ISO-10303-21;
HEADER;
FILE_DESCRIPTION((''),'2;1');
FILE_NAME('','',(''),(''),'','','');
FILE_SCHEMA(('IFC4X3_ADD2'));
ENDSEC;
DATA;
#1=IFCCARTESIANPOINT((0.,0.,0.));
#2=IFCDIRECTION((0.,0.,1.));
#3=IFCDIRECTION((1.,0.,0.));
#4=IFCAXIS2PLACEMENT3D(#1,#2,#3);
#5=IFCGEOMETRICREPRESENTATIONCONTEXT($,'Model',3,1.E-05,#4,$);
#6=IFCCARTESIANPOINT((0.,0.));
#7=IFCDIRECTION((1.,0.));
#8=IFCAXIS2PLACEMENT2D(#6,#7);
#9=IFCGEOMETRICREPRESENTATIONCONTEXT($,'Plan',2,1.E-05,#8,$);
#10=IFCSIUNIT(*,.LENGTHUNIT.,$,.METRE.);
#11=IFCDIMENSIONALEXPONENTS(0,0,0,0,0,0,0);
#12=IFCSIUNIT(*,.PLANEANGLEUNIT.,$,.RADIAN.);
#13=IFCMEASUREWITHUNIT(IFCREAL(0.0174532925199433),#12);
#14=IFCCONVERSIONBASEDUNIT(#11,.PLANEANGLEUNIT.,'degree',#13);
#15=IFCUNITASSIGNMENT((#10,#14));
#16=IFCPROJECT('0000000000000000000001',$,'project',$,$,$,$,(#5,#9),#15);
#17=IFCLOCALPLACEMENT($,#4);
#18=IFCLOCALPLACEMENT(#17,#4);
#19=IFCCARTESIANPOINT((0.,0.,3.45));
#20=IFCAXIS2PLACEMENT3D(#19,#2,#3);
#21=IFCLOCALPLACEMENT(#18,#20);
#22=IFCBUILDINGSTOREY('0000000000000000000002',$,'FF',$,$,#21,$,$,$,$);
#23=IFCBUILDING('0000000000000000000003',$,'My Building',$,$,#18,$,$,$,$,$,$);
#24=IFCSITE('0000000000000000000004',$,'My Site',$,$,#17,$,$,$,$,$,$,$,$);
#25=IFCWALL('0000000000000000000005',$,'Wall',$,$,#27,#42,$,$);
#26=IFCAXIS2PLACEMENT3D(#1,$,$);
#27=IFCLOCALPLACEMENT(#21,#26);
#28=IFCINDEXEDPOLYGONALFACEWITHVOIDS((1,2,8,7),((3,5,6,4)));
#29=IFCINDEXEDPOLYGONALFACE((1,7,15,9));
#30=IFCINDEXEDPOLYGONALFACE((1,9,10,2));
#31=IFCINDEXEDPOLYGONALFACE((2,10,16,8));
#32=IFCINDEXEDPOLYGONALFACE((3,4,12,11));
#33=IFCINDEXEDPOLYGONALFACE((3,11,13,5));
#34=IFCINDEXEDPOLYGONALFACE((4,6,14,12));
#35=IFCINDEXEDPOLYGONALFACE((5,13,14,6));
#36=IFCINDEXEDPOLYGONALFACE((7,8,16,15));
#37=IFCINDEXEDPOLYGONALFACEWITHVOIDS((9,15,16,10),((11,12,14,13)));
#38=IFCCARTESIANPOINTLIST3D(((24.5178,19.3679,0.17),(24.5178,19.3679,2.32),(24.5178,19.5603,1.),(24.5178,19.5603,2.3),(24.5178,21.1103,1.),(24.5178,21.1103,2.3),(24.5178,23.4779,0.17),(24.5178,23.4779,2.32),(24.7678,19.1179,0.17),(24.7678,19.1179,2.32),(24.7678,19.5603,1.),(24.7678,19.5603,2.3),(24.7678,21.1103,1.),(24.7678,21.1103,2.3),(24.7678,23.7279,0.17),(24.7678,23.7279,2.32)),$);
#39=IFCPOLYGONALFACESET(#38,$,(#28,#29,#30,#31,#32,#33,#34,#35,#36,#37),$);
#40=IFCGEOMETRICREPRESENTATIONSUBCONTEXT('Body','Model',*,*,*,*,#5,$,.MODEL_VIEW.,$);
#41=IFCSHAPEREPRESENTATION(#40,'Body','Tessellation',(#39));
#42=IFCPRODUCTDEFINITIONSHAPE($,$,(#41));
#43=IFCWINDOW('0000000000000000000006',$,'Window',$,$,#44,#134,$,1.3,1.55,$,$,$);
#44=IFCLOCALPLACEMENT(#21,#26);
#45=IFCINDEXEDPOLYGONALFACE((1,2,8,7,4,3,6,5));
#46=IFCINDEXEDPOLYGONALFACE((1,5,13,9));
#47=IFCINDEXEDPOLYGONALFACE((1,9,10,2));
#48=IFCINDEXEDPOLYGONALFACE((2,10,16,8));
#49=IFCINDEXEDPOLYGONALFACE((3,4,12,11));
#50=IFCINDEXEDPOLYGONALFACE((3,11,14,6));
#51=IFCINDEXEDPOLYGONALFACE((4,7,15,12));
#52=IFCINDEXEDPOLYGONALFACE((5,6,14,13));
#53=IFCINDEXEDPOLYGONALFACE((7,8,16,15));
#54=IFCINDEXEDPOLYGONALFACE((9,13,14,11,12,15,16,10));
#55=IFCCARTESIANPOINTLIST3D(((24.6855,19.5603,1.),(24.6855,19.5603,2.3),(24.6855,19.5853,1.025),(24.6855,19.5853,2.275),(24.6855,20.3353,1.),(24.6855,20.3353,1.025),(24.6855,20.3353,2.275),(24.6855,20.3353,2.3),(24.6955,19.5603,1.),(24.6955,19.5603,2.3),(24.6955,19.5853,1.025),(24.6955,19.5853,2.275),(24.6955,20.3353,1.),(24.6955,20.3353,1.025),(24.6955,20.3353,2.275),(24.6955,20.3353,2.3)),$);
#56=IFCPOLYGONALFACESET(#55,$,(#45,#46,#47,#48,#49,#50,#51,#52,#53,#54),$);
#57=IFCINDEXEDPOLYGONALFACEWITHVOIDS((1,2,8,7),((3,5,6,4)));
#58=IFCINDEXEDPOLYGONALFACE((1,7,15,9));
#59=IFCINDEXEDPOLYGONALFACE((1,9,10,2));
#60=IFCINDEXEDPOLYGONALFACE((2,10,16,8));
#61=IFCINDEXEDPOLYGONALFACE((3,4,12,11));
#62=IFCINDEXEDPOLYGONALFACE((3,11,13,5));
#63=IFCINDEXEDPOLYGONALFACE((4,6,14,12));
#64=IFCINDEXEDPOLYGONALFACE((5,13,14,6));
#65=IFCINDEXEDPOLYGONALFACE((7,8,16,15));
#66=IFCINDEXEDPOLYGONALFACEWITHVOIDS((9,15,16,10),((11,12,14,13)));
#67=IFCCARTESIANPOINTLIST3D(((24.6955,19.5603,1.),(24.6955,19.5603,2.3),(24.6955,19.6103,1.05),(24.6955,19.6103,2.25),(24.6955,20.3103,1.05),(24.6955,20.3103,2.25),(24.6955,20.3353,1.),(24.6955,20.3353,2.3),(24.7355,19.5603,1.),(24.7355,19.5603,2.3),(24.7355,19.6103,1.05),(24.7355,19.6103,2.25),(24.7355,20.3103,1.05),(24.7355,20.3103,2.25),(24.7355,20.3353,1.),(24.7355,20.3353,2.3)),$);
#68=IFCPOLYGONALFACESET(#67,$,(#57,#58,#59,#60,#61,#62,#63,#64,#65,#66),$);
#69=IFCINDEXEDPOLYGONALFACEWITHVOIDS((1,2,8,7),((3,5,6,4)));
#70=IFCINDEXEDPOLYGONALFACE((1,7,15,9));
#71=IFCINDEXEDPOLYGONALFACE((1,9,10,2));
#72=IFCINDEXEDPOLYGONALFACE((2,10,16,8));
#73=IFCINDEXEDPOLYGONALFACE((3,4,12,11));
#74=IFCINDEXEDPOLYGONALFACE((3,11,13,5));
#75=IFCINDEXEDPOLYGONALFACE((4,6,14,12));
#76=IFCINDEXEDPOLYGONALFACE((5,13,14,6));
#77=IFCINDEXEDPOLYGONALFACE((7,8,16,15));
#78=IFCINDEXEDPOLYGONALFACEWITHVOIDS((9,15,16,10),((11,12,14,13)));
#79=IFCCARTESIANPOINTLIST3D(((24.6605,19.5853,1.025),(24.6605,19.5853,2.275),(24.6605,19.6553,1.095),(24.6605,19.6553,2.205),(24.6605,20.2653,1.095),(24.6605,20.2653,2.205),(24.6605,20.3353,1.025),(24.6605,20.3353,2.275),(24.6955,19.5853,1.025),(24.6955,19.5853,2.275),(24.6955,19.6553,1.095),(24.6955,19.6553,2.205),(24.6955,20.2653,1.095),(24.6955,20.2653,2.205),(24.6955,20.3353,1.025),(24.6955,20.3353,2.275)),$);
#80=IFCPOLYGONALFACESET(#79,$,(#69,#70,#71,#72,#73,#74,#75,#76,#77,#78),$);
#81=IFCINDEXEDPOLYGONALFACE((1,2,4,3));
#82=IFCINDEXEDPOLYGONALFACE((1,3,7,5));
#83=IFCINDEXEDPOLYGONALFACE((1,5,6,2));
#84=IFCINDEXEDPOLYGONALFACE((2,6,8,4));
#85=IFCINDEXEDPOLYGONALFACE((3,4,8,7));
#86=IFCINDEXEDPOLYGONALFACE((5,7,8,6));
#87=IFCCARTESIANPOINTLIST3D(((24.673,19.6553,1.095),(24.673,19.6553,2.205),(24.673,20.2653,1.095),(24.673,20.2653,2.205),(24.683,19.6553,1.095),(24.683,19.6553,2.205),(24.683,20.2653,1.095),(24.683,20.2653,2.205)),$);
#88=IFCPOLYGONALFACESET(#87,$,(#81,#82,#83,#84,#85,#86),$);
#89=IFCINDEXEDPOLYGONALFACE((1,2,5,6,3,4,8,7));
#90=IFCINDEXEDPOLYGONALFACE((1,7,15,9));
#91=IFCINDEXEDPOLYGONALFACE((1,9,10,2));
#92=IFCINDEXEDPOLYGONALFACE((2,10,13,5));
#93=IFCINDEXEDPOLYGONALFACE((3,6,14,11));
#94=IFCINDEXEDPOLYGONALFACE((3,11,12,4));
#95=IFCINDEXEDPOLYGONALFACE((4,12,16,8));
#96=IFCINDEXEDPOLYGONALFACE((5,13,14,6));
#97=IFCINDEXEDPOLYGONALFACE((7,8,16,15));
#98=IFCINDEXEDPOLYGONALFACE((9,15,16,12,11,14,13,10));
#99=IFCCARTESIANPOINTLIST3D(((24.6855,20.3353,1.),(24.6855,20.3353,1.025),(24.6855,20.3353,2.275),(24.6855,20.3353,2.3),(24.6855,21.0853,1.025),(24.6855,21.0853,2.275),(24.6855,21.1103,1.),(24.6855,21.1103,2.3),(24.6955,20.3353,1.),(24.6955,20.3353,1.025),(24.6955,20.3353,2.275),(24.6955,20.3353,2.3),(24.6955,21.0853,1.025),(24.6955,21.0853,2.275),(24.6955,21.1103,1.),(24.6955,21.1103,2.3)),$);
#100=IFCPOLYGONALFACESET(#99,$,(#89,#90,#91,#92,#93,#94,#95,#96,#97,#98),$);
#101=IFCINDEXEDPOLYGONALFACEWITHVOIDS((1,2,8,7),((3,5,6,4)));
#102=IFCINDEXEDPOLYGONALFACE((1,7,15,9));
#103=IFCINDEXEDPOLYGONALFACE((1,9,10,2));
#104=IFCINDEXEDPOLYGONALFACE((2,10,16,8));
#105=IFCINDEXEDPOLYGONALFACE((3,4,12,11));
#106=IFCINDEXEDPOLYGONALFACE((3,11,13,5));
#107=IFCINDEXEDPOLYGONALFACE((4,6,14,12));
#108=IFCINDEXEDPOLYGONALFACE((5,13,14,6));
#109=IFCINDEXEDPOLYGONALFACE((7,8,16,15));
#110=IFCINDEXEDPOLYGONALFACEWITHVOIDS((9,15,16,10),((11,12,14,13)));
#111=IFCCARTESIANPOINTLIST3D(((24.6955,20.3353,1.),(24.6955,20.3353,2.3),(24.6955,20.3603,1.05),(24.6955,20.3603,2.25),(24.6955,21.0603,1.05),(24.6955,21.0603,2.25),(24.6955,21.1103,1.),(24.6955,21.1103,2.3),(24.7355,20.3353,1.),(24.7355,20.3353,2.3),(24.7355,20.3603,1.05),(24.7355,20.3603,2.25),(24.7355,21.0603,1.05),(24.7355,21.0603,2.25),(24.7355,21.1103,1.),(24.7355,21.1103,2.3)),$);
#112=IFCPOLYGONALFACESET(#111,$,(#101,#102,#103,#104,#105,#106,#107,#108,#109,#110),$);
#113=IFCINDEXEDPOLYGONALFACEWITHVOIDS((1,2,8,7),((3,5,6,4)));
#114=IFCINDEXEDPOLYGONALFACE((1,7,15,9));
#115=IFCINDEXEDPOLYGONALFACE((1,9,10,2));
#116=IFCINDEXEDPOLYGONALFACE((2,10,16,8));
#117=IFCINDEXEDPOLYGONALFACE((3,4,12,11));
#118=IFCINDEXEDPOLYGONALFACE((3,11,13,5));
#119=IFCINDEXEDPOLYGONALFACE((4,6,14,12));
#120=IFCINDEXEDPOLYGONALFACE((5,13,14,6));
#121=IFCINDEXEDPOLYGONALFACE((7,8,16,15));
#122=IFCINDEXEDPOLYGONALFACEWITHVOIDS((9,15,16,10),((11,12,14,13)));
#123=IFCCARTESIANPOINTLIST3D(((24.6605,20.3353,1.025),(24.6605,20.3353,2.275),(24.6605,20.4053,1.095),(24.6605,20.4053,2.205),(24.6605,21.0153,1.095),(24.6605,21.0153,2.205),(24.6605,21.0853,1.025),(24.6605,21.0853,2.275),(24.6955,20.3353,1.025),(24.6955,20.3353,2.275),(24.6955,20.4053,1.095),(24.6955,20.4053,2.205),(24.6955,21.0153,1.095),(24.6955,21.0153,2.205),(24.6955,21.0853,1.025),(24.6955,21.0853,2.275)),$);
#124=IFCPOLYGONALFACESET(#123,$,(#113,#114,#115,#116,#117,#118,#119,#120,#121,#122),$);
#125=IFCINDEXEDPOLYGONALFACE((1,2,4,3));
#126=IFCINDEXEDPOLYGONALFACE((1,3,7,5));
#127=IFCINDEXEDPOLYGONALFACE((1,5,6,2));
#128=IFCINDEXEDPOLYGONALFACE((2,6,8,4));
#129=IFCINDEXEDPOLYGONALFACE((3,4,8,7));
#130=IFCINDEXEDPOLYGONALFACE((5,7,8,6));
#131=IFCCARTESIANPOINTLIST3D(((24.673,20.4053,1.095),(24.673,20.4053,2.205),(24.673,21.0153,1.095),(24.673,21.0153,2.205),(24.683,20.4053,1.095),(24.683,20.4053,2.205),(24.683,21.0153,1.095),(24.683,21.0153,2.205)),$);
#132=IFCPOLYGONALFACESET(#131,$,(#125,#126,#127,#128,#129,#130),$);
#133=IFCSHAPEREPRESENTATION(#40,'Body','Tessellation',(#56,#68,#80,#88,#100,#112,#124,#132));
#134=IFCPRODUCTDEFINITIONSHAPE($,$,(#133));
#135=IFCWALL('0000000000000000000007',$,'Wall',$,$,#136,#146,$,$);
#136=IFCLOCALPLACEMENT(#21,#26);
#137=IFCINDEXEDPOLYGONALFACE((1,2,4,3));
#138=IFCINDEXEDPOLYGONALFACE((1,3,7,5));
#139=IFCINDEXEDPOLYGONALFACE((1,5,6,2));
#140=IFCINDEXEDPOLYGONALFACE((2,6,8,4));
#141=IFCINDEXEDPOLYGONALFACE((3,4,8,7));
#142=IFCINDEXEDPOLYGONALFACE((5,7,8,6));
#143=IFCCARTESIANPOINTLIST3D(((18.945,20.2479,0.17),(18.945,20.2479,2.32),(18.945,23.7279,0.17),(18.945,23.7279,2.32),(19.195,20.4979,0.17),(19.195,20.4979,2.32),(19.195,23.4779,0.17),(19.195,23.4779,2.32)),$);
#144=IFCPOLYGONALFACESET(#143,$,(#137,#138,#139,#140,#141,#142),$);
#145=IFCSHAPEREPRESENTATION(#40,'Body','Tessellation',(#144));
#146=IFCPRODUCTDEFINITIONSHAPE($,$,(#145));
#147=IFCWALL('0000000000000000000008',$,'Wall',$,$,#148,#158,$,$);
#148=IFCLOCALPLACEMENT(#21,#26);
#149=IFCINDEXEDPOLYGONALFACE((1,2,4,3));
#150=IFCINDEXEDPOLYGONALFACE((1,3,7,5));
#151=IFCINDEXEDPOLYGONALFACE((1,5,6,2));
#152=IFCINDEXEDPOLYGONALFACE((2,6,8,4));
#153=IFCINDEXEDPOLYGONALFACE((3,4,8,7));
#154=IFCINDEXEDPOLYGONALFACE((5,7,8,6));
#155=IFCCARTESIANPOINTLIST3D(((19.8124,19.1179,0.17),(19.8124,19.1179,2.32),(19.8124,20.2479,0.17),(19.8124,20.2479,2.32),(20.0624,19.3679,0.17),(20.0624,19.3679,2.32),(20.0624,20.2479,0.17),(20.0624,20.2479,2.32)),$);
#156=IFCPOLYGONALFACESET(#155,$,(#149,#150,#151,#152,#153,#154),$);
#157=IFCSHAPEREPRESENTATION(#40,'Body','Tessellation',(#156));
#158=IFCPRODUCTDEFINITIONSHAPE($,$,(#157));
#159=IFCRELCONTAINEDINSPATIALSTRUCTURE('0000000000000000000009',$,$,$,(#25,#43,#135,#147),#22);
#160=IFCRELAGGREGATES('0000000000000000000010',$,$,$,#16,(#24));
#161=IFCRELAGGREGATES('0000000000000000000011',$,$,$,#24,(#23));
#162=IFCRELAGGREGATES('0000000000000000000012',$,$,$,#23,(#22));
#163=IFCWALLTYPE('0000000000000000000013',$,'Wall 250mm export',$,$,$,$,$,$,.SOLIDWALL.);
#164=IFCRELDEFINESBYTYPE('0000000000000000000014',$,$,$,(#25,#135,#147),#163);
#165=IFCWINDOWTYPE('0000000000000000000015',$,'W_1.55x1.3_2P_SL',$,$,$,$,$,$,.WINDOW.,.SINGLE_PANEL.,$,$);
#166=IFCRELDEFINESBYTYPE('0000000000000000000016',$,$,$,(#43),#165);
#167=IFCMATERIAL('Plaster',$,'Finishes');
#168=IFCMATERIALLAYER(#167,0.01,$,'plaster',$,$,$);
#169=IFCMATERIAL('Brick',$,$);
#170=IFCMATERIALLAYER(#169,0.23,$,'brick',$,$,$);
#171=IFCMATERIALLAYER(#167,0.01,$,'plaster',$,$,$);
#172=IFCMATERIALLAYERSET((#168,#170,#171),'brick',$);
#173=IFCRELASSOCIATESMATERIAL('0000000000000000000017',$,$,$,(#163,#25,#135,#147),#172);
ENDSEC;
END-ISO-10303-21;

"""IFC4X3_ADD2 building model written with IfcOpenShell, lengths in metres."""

from ifc_helpers import new_model, entity, si_unit, converted_unit, frame, origin_with_axes, origin_2d_with_axis, place, context, subcontext, project, spatial, line, indexed_curve, outline, extrude, shape, source, transform, mapped, material, layer, layer_set, layer_usage, type_object, type_shapes, element, fill, save


model = new_model("IFC4X3_ADD2")

# Units and contexts
model_context = context("Model", 3, precision=1e-05, world=origin_with_axes())
plan_context = context("Plan", 2, precision=1e-05, world=origin_2d_with_axis())
body_context_1 = subcontext(model_context, "Body", "Model", "MODEL_VIEW")
body_context_2 = subcontext(plan_context, "Body", "Plan", "PLAN_VIEW")
ifc_project = project(units=[si_unit("LENGTHUNIT", "METRE"), converted_unit("PLANEANGLEUNIT", "degree", entity("IfcReal", 0.0174532925199433), si_unit("PLANEANGLEUNIT", "RADIAN"), dimensions=[0, 0, 0, 0, 0, 0, 0])], contexts=[model_context, plan_context])

# Site, building, storey
site_placement = place(None, origin_with_axes())
site = spatial("IfcSite", under=ifc_project, at=site_placement, Name="My Site")
building_placement = place(site_placement, origin_with_axes())
building = spatial("IfcBuilding", under=site, at=building_placement, Name="My Building")
storey_placement = place(building_placement, frame((0.0, 0.0, 3.45), z_axis=(0.0, 0.0, 1.0), x_axis=(1.0, 0.0, 0.0)))
storey = spatial("IfcBuildingStorey", under=building, at=storey_placement, Name="FF")

# Shared definitions
ifc_material_1 = material(Name="Plaster", Category="Finishes")
ifc_layer_1 = layer(ifc_material_1, 0.01, Name="plaster")
ifc_material_2 = material(Name="Brick")
ifc_layer_2 = layer(ifc_material_2, 0.23, Name="brick")
ifc_layer_3 = layer(ifc_material_1, 0.01, Name="plaster")
ifc_layer_set_1 = layer_set([ifc_layer_1, ifc_layer_2, ifc_layer_3], Name="brick")
wall_type_1 = type_object("IfcWallType", Name="Wall 250mm export", PredefinedType="SOLIDWALL", material=ifc_layer_set_1)

# Wall, opening, window
ifc_layer_usage_1 = layer_usage(ifc_layer_set_1, "AXIS2", "POSITIVE", 0.0)
wall_1_placement = place(storey_placement, frame((24.7678, 19.1179, 0.17), z_axis=(0.0, 0.0, 1.0), x_axis=(0.0, 1.0, 0.0)))
wall_1 = element("IfcWall", 1, at=wall_1_placement, inside=storey, type_object=wall_type_1, material=ifc_layer_usage_1, Name="Wall", context=body_context_1, shape_type="SweptSolid", body=[
    extrude(outline(indexed_curve([(0.0, 0.0), (0.25, 0.25), (4.36, 0.25), (4.61, 0.0)], segments=[line(1, 2, 3, 4, 1)])), origin_with_axes(), (0.0, 0.0, 1.0), 2.15),
])
shared_shape_1 = source(origin_with_axes(), body_context_1, "Body", "SweptSolid", [
    extrude(outline(indexed_curve([(0.0, 0.0), (1.55, 0.0), (1.55, 1.3), (0.0, 1.3)], segments=[line(1, 2, 3, 4, 1)])), frame((0.0, -0.6, 0.0), z_axis=(0.0, -1.0, 0.0), x_axis=(1.0, 0.0, 0.0)), (0.0, 0.0, -1.0), 1.2),
])
opening_1_placement = place(wall_1_placement, frame((0.4424, -0.2129, 0.83), z_axis=(0.0, 0.0, 1.0), x_axis=(1.0, 0.0, 0.0)))
opening_1 = element("IfcOpeningElement", 2, at=opening_1_placement, cuts=wall_1, PredefinedType="OPENING", context=body_context_1, shape_type="MappedRepresentation", body=[
    mapped(shared_shape_1, transform((0.0, 0.0, 0.0), x_axis=(1.0, 0.0, 0.0), y_axis=(0.0, 1.0, 0.0), z_axis=(0.0, 0.0, 1.0), scale=1.0)),
])
window_type = type_object("IfcWindowType", Name="W_1.55x1.3_2P_SL", PartitioningType="SINGLE_PANEL", PredefinedType="WINDOW")
shared_shape_2 = source(origin_with_axes(), body_context_1, "Body", "SweptSolid", [
    extrude(outline(indexed_curve([(0.775, 0.0), (0.0, 0.0), (0.0, 1.3), (0.775, 1.3), (0.775, 1.275), (0.025, 1.275), (0.025, 0.025), (0.775, 0.025)], segments=[line(1, 2, 3, 4, 5, 6, 7, 8, 1)])), frame((0.0, 0.09, 0.0), z_axis=(0.0, -1.0, 0.0), x_axis=(1.0, 0.0, 0.0)), (0.0, 0.0, -1.0), 0.01),
    extrude(outline(indexed_curve([(0.0, 0.0), (0.775, 0.0), (0.775, 1.3), (0.0, 1.3)], segments=[line(1, 2, 3, 4, 1)]), holes=[indexed_curve([(0.05, 0.05), (0.75, 0.05), (0.75, 1.25), (0.05, 1.25)], segments=[line(1, 2, 3, 4, 1)])]), frame((0.0, 0.05, 0.0), z_axis=(0.0, -1.0, 0.0), x_axis=(1.0, 0.0, 0.0)), (0.0, 0.0, -1.0), 0.04),
    extrude(outline(indexed_curve([(0.0, 0.0), (0.75, 0.0), (0.75, 1.25), (0.0, 1.25)], segments=[line(1, 2, 3, 4, 1)]), holes=[indexed_curve([(0.07, 0.07), (0.68, 0.07), (0.68, 1.18), (0.07, 1.18)], segments=[line(1, 2, 3, 4, 1)])]), frame((0.025, 0.09, 0.025), z_axis=(0.0, -1.0, 0.0), x_axis=(1.0, 0.0, 0.0)), (0.0, 0.0, -1.0), 0.035),
    extrude(outline(indexed_curve([(0.07, 0.07), (0.68, 0.07), (0.68, 1.18), (0.07, 1.18)], segments=[line(1, 2, 3, 4, 1)])), frame((0.025, 0.1025, 0.025), z_axis=(0.0, -1.0, 0.0), x_axis=(1.0, 0.0, 0.0)), (0.0, 0.0, -1.0), 0.01),
    extrude(outline(indexed_curve([(0.0, 1.3), (0.775, 1.3), (0.775, 0.0), (0.0, 0.0), (0.0, 0.025), (0.75, 0.025), (0.75, 1.275), (0.0, 1.275)], segments=[line(1, 2, 3, 4, 5, 6, 7, 8, 1)])), frame((0.775, 0.09, 0.0), z_axis=(0.0, -1.0, 0.0), x_axis=(1.0, 0.0, 0.0)), (0.0, 0.0, -1.0), 0.01),
    extrude(outline(indexed_curve([(0.0, 0.0), (0.775, 0.0), (0.775, 1.3), (0.0, 1.3)], segments=[line(1, 2, 3, 4, 1)]), holes=[indexed_curve([(0.025, 0.05), (0.725, 0.05), (0.725, 1.25), (0.025, 1.25)], segments=[line(1, 2, 3, 4, 1)])]), frame((0.775, 0.05, 0.0), z_axis=(0.0, -1.0, 0.0), x_axis=(1.0, 0.0, 0.0)), (0.0, 0.0, -1.0), 0.04),
    extrude(outline(indexed_curve([(0.0, 0.0), (0.75, 0.0), (0.75, 1.25), (0.0, 1.25)], segments=[line(1, 2, 3, 4, 1)]), holes=[indexed_curve([(0.07, 0.07), (0.68, 0.07), (0.68, 1.18), (0.07, 1.18)], segments=[line(1, 2, 3, 4, 1)])]), frame((0.775, 0.09, 0.025), z_axis=(0.0, -1.0, 0.0), x_axis=(1.0, 0.0, 0.0)), (0.0, 0.0, -1.0), 0.035),
    extrude(outline(indexed_curve([(0.07, 0.07), (0.68, 0.07), (0.68, 1.18), (0.07, 1.18)], segments=[line(1, 2, 3, 4, 1)])), frame((0.775, 0.1025, 0.025), z_axis=(0.0, -1.0, 0.0), x_axis=(1.0, 0.0, 0.0)), (0.0, 0.0, -1.0), 0.01),
])
shared_shape_3 = source(origin_with_axes(), body_context_2, "Body", "Curve2D", [
    entity("IfcIndexedPolyCurve", entity("IfcCartesianPointList2D", [[0.05, 0.05], [0.75, 0.05]])),
    entity("IfcIndexedPolyCurve", entity("IfcCartesianPointList2D", [[0.0, 0.1], [0.025, 0.1], [0.025, 0.09], [0.05, 0.09], [0.05, 0.05], [0.0, 0.05]]), [entity("IfcLineIndex", [1, 2, 3, 4, 5, 6, 1])]),
    entity("IfcIndexedPolyCurve", entity("IfcCartesianPointList2D", [[0.775, 0.1], [0.775, 0.1], [0.775, 0.09], [0.75, 0.09], [0.75, 0.05], [0.775, 0.05]])),
    entity("IfcIndexedPolyCurve", entity("IfcCartesianPointList2D", [[0.025, 0.09], [0.095, 0.09], [0.095, 0.125], [0.025, 0.125]]), [entity("IfcLineIndex", [1, 2, 3, 4, 1])]),
    entity("IfcIndexedPolyCurve", entity("IfcCartesianPointList2D", [[0.775, 0.09], [0.705, 0.09], [0.705, 0.125], [0.775, 0.125]]), [entity("IfcLineIndex", [1, 2, 3, 4, 1])]),
    entity("IfcIndexedPolyCurve", entity("IfcCartesianPointList2D", [[0.095, 0.09], [0.705, 0.09]])),
    entity("IfcIndexedPolyCurve", entity("IfcCartesianPointList2D", [[0.095, 0.125], [0.705, 0.125]])),
    entity("IfcIndexedPolyCurve", entity("IfcCartesianPointList2D", [[0.095, 0.1075], [0.705, 0.1075]])),
    entity("IfcIndexedPolyCurve", entity("IfcCartesianPointList2D", [[0.8, 0.05], [1.5, 0.05]])),
    entity("IfcIndexedPolyCurve", entity("IfcCartesianPointList2D", [[0.775, 0.1], [0.775, 0.1], [0.775, 0.09], [0.8, 0.09], [0.8, 0.05], [0.775, 0.05]])),
    entity("IfcIndexedPolyCurve", entity("IfcCartesianPointList2D", [[1.55, 0.1], [1.525, 0.1], [1.525, 0.09], [1.5, 0.09], [1.5, 0.05], [1.55, 0.05]]), [entity("IfcLineIndex", [1, 2, 3, 4, 5, 6, 1])]),
    entity("IfcIndexedPolyCurve", entity("IfcCartesianPointList2D", [[0.775, 0.09], [0.845, 0.09], [0.845, 0.125], [0.775, 0.125]]), [entity("IfcLineIndex", [1, 2, 3, 4, 1])]),
    entity("IfcIndexedPolyCurve", entity("IfcCartesianPointList2D", [[1.525, 0.09], [1.455, 0.09], [1.455, 0.125], [1.525, 0.125]]), [entity("IfcLineIndex", [1, 2, 3, 4, 1])]),
    entity("IfcIndexedPolyCurve", entity("IfcCartesianPointList2D", [[0.845, 0.09], [1.455, 0.09]])),
    entity("IfcIndexedPolyCurve", entity("IfcCartesianPointList2D", [[0.845, 0.125], [1.455, 0.125]])),
    entity("IfcIndexedPolyCurve", entity("IfcCartesianPointList2D", [[0.845, 0.1075], [1.455, 0.1075]])),
])
type_shapes(window_type, [shared_shape_2, shared_shape_3])
window_placement = place(opening_1_placement, frame((0.0, 0.1952, 0.0), z_axis=(0.0, 0.0, 1.0), x_axis=(1.0, 0.0, 0.0)))
window = element("IfcWindow", 3, at=window_placement, inside=storey, type_object=window_type, Name="Window", OverallHeight=1.3, OverallWidth=1.55, shapes=[
    shape(body_context_1, "Body", "MappedRepresentation", [mapped(shared_shape_2, transform((0.0, 0.0, 0.0), x_axis=(1.0, 0.0, 0.0), y_axis=(0.0, 1.0, 0.0), z_axis=(0.0, 0.0, 1.0), scale=1.0))]),
    shape(body_context_2, "Body", "MappedRepresentation", [mapped(shared_shape_3, transform((0.0, 0.0, 0.0), x_axis=(1.0, 0.0, 0.0), y_axis=(0.0, 1.0, 0.0), z_axis=(0.0, 0.0, 1.0), scale=1.0))]),
])
fill(opening_1, window)

# Walls
ifc_layer_usage_2 = layer_usage(ifc_layer_set_1, "AXIS2", "POSITIVE", 0.0)
wall_2_placement = place(storey_placement, frame((19.195, 20.2479, 0.17), z_axis=(0.0, 0.0, 1.0), x_axis=(0.0, 1.0, 0.0)))
element("IfcWall", 4, at=wall_2_placement, inside=storey, type_object=wall_type_1, material=ifc_layer_usage_2, Name="Wall", context=body_context_1, shape_type="SweptSolid", body=[
    extrude(outline(indexed_curve([(0.25, 0.0), (0.0, 0.25), (3.48, 0.25), (3.23, 0.0)], segments=[line(1, 2, 3, 4, 1)])), origin_with_axes(), (0.0, 0.0, 1.0), 2.15),
])
ifc_layer_usage_3 = layer_usage(ifc_layer_set_1, "AXIS2", "POSITIVE", 0.0)
wall_3_placement = place(storey_placement, frame((20.0624, 19.1179, 0.17), z_axis=(0.0, 0.0, 1.0), x_axis=(0.0, 1.0, 0.0)))
element("IfcWall", 5, at=wall_3_placement, inside=storey, type_object=wall_type_1, material=ifc_layer_usage_3, Name="Wall", context=body_context_1, shape_type="SweptSolid", body=[
    extrude(outline(indexed_curve([(0.25, 0.0), (0.0, 0.25), (1.13, 0.25), (1.13, 0.0)], segments=[line(1, 2, 3, 4, 1)])), origin_with_axes(), (0.0, 0.0, 1.0), 2.15),
])

save(model, "model.ifc")
